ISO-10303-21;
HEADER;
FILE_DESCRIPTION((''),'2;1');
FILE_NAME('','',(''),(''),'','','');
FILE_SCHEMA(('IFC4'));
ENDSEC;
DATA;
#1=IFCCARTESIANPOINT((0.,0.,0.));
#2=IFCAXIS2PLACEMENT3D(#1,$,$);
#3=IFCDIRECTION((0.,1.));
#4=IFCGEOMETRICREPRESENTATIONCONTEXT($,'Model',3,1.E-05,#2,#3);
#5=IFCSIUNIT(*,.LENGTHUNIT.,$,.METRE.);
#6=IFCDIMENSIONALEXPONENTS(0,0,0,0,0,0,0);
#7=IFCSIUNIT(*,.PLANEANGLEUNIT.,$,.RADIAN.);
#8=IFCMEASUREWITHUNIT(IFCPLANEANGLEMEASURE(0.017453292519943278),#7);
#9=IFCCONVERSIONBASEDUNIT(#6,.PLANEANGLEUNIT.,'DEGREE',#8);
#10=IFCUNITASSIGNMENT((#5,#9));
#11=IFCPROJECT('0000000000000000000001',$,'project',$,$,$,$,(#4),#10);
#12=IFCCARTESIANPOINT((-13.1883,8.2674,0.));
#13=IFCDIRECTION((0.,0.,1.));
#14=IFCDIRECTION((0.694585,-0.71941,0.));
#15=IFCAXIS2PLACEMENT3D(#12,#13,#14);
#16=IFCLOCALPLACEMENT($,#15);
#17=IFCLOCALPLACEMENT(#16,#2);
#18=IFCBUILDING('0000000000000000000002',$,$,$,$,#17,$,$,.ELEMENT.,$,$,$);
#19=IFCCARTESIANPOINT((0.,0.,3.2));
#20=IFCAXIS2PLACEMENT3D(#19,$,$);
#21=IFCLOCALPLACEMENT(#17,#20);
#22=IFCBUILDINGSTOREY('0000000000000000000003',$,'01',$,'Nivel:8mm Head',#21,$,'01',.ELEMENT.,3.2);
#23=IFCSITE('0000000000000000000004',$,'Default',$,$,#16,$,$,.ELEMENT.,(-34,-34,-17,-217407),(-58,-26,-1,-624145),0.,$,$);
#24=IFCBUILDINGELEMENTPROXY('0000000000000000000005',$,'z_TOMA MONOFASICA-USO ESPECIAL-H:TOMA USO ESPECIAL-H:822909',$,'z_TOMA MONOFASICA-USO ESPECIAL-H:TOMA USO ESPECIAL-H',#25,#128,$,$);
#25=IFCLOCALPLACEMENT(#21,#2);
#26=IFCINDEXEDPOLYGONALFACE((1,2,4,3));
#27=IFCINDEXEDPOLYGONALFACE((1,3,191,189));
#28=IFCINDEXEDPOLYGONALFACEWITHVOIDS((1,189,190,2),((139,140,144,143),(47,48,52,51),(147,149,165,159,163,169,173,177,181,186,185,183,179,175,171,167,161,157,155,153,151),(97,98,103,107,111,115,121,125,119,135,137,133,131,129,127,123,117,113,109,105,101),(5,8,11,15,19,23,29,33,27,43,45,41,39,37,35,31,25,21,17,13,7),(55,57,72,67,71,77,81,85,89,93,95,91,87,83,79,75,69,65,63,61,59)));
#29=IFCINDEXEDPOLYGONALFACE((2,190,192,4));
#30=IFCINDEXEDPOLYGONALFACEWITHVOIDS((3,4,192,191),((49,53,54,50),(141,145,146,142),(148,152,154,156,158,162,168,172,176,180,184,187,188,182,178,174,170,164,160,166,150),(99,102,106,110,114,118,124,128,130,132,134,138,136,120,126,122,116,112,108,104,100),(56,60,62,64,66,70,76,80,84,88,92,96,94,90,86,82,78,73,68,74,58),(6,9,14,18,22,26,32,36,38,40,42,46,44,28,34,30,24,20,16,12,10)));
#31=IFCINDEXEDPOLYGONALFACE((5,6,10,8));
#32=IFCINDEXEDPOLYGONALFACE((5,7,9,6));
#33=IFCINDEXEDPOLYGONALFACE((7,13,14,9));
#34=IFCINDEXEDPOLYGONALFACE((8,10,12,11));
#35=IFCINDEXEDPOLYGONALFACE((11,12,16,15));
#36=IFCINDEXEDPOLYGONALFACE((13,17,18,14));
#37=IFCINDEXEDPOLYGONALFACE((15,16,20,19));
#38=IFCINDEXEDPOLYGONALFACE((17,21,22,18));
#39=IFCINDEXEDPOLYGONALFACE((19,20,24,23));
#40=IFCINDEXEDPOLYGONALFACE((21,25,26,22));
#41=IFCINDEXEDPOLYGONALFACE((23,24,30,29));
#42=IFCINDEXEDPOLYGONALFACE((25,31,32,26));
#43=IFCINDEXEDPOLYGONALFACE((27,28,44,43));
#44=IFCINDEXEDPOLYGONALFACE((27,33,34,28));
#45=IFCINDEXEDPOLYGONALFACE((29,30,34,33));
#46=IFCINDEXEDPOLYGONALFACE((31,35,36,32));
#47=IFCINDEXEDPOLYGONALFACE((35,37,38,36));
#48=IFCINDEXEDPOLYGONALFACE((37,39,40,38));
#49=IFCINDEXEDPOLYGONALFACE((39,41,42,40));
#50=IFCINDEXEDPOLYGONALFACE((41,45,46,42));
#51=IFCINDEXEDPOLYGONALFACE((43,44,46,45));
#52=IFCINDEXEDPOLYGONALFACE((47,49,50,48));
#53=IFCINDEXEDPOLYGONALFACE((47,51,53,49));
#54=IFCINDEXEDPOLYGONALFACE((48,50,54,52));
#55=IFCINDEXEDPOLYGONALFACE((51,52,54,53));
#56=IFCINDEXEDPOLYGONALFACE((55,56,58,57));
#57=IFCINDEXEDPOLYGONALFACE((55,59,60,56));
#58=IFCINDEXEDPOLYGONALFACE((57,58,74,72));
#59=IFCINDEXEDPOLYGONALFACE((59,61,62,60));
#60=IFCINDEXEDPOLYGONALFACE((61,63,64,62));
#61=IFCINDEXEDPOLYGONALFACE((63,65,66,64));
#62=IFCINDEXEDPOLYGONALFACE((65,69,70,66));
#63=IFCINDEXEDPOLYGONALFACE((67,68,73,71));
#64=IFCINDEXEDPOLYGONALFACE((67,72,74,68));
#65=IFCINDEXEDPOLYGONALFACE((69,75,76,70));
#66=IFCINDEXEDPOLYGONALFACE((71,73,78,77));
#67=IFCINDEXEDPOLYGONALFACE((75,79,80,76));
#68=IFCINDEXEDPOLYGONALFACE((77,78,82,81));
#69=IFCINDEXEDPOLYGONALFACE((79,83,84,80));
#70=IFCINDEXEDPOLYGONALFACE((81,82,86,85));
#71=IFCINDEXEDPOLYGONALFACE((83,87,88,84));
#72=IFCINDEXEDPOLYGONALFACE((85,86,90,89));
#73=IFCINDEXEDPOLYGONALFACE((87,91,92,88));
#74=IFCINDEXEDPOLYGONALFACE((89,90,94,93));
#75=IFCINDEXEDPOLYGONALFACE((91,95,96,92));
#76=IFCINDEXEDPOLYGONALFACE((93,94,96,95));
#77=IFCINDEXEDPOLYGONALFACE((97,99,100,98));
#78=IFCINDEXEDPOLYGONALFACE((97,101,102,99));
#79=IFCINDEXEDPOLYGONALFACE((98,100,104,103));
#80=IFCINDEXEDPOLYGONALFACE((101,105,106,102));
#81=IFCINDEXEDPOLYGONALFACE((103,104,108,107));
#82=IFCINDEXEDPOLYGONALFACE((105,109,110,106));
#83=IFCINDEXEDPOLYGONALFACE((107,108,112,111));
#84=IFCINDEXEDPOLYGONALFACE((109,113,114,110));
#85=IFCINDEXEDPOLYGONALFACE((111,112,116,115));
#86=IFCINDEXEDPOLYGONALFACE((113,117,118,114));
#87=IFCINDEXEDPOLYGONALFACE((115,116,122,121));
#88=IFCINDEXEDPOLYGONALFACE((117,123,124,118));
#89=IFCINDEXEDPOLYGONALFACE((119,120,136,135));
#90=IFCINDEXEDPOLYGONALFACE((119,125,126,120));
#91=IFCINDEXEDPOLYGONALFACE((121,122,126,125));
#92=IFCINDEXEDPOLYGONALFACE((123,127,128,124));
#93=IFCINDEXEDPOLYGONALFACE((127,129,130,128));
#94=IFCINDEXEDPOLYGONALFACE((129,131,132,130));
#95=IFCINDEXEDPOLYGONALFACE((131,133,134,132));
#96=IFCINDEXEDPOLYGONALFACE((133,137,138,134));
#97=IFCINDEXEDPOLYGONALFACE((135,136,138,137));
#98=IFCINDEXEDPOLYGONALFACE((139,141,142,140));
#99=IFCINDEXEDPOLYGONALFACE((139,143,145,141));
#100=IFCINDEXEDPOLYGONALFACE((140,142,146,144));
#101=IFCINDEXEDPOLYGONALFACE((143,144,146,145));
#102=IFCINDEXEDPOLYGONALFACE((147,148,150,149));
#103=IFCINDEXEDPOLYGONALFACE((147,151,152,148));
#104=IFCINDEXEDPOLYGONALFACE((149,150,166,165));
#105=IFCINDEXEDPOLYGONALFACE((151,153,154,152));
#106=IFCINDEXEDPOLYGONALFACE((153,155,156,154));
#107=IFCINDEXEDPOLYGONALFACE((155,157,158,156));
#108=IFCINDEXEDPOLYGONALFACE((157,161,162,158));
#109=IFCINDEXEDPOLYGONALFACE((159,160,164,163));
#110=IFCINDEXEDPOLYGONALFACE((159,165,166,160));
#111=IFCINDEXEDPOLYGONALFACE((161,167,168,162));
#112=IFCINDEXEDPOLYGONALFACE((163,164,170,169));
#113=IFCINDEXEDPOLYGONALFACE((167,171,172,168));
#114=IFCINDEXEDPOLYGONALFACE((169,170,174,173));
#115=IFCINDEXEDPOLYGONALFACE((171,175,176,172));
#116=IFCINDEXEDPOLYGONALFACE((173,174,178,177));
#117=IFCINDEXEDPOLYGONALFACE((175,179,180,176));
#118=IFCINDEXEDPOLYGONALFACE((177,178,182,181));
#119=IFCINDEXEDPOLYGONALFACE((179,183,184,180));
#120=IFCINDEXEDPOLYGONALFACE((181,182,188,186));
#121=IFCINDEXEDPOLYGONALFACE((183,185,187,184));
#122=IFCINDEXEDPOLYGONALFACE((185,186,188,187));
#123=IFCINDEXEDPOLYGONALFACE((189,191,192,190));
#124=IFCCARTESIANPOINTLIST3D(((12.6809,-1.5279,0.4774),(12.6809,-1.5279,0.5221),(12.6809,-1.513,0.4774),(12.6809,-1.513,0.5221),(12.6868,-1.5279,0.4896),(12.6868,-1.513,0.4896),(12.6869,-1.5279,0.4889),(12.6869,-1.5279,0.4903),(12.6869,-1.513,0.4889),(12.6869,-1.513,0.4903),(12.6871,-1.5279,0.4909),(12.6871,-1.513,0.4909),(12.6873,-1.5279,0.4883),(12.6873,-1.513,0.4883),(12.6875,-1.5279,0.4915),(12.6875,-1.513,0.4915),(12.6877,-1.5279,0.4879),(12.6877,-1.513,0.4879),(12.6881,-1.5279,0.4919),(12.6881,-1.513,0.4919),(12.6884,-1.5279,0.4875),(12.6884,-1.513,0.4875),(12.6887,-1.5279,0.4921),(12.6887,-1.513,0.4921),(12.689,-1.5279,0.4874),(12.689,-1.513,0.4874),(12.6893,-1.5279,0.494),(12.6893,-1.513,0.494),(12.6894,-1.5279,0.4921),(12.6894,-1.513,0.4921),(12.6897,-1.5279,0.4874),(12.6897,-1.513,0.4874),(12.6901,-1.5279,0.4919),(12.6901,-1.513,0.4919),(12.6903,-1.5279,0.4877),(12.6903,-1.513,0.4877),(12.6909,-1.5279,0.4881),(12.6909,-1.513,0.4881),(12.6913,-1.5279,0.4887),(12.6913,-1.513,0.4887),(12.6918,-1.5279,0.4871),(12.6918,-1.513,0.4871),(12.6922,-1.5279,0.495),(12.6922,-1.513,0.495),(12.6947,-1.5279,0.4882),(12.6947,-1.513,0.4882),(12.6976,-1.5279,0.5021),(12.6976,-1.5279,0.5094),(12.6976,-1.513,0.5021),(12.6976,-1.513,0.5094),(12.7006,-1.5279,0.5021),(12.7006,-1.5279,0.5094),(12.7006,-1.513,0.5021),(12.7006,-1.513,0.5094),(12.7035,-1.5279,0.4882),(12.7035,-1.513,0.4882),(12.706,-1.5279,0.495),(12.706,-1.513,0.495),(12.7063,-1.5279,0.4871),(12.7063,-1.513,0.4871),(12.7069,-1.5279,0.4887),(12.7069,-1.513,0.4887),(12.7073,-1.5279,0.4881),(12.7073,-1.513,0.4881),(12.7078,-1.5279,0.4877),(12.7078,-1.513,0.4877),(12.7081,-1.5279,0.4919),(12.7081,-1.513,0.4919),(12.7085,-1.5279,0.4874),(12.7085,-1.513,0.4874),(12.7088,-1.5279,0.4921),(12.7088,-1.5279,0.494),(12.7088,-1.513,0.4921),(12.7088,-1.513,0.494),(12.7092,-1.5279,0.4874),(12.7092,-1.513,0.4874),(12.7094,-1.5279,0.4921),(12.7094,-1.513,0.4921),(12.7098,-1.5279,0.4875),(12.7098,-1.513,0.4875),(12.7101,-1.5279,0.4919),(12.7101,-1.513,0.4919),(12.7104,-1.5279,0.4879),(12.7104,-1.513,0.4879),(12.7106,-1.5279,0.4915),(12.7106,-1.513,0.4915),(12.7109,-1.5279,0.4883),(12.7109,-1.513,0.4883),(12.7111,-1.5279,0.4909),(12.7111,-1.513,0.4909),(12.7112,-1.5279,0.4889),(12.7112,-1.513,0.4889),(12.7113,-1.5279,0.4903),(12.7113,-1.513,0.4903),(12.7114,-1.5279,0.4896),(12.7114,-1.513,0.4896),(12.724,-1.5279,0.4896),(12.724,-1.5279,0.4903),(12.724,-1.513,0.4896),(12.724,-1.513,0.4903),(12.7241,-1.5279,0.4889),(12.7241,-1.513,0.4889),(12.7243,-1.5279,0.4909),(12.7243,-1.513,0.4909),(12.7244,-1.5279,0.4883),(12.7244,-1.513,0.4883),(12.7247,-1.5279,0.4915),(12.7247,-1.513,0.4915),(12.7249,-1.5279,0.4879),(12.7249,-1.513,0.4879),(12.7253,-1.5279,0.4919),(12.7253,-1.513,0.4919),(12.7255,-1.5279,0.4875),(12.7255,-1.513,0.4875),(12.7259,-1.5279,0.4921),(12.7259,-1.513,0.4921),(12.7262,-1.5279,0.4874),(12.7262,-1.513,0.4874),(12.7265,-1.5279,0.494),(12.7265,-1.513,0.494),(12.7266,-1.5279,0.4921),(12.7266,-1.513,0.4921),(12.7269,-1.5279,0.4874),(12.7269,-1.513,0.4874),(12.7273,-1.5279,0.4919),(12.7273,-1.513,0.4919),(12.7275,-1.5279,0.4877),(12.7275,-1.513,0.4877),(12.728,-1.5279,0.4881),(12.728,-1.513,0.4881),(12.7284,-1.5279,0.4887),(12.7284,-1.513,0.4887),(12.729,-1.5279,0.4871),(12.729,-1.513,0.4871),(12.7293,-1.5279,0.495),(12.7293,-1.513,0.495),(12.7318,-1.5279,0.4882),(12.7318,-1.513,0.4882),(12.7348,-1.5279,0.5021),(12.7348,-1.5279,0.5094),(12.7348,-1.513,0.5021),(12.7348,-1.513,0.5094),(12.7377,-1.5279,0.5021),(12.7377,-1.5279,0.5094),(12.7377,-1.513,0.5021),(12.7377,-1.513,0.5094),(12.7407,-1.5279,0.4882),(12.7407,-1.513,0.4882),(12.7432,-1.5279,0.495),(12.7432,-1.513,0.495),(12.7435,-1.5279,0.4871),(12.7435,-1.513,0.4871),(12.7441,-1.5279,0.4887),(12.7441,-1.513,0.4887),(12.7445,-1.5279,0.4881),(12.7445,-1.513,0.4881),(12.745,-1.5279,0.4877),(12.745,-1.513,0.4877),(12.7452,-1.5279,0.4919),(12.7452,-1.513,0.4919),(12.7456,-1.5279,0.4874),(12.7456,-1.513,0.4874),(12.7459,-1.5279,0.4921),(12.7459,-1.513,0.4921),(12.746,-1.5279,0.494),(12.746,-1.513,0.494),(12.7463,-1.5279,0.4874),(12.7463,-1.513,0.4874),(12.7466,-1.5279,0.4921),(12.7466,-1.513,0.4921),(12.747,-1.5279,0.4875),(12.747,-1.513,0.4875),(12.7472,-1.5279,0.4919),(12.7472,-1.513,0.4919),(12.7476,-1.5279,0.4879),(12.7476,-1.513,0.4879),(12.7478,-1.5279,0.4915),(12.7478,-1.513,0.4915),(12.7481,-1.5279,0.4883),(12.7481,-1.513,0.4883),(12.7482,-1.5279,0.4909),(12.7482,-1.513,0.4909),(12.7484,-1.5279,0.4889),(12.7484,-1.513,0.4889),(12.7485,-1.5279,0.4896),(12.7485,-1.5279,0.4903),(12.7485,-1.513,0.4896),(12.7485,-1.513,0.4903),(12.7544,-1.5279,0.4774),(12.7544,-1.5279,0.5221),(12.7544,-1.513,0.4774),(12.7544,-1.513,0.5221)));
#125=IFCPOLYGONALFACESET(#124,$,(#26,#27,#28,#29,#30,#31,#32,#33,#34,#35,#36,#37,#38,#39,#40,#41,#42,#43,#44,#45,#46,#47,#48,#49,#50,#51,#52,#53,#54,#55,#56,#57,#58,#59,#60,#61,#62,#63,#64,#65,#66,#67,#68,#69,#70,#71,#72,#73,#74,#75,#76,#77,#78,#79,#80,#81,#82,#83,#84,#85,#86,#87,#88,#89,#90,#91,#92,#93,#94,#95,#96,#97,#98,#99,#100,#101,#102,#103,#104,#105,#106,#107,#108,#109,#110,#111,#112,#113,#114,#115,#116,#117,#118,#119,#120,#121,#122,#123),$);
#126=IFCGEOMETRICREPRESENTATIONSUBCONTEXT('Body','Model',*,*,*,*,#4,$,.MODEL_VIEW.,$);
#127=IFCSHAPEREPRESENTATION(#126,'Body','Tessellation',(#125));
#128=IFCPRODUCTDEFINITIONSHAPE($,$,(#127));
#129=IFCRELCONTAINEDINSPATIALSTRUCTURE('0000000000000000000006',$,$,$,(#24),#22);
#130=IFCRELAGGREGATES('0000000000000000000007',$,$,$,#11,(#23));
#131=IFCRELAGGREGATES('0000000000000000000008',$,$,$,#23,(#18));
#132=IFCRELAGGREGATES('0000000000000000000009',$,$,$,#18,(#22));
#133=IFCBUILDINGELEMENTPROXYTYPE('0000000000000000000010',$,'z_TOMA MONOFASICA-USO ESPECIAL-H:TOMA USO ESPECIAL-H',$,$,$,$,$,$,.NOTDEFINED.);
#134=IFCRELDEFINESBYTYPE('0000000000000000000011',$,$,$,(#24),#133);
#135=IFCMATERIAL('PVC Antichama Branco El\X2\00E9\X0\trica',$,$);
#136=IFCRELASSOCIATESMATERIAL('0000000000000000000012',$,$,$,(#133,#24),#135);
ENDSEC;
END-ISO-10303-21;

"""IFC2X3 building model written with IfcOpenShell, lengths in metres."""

from ifc_helpers import new_model, entity, si_unit, converted_unit, direction, frame, frame_2d, origin, place, context, subcontext, project, spatial, polyline, circle_curve, parameter, trimmed, segment, composite_curve, outline, extrude, source, transform, mapped, material, type_object, type_shapes, element, save


model = new_model("IFC2X3")

# Units and contexts
model_context = context("Model", 3, precision=1e-05, world=origin(), true_north=direction((0.0, 1.0)))
body_context = subcontext(model_context, "Body", "Model", "MODEL_VIEW")
ifc_project = project(units=[si_unit("LENGTHUNIT", "METRE"), converted_unit("PLANEANGLEUNIT", "DEGREE", entity("IfcPlaneAngleMeasure", 0.017453292519943278), si_unit("PLANEANGLEUNIT", "RADIAN"), dimensions=[0, 0, 0, 0, 0, 0, 0])], contexts=[model_context])

# Site, building, storey
site_placement = place(None, frame((-13.1883, 8.2674, 0.0), z_axis=(0.0, 0.0, 1.0), x_axis=(0.694585, -0.71941, 0.0)))
site = spatial("IfcSite", under=ifc_project, at=site_placement, Name="Default", CompositionType="ELEMENT", RefLatitude=(-34, -34, -17, -217407), RefLongitude=(-58, -26, -1, -624145), RefElevation=0.0)
building_placement = place(site_placement, origin())
building = spatial("IfcBuilding", under=site, at=building_placement, CompositionType="ELEMENT")
storey_placement = place(building_placement, frame((0.0, 0.0, 3.2)))
storey = spatial("IfcBuildingStorey", under=building, at=storey_placement, Name="01", ObjectType="Nivel:8mm Head", LongName="01", CompositionType="ELEMENT", Elevation=3.2)

# Building element proxy
ifc_material_1 = material(Name="PVC Antichama Branco Elétrica")
building_element_proxy_type_1 = type_object("IfcBuildingElementProxyType", Name="z_TOMA MONOFASICA-USO ESPECIAL-H:TOMA USO ESPECIAL-H", PredefinedType="NOTDEFINED", material=ifc_material_1)
shared_shape_1 = source(origin(), body_context, "Body", "SweptSolid", [
    extrude(outline(polyline([(-0.0368, -0.0223), (0.0368, -0.0223), (0.0368, 0.0223), (-0.0368, 0.0223), (-0.0368, -0.0223)]), holes=[composite_curve([segment(polyline([(0.0141, 0.0115), (0.0116, 0.0047)]), True, "CONTINUOUS"), segment(polyline([(0.0116, 0.0047), (0.0088, 0.0057)]), True, "CONTINUOUS"), segment(polyline([(0.0088, 0.0057), (0.0096, 0.0078)]), True, "CONTINUOUS"), segment(trimmed(circle_curve(frame_2d((0.0087, 0.0099), x_axis=(1.0, 0.0)), 0.0024), [parameter(27.118901)], [parameter(292.881099)], True, "PARAMETER"), False, "CONTINUOUS"), segment(polyline([(0.0108, 0.011), (0.0113, 0.0126)]), True, "CONTINUOUS"), segment(polyline([(0.0113, 0.0126), (0.0141, 0.0115)]), True, "CONTINUOUS")], self_intersect=False), composite_curve([segment(polyline([(0.0255, 0.0047), (0.023, 0.0115)]), True, "CONTINUOUS"), segment(polyline([(0.023, 0.0115), (0.0258, 0.0126)]), True, "CONTINUOUS"), segment(polyline([(0.0258, 0.0126), (0.0264, 0.011)]), True, "CONTINUOUS"), segment(trimmed(circle_curve(frame_2d((0.0285, 0.0099), x_axis=(1.0, 0.0)), 0.0024), [parameter(247.118901)], [parameter(152.881099)], True, "PARAMETER"), False, "CONTINUOUS"), segment(polyline([(0.0276, 0.0078), (0.0283, 0.0057)]), True, "CONTINUOUS"), segment(polyline([(0.0283, 0.0057), (0.0255, 0.0047)]), True, "CONTINUOUS")], self_intersect=False), polyline([(0.0201, -0.0024), (0.0201, -0.0097), (0.0171, -0.0097), (0.0171, -0.0024), (0.0201, -0.0024)]), composite_curve([segment(polyline([(-0.0141, 0.0115), (-0.0113, 0.0126)]), True, "CONTINUOUS"), segment(polyline([(-0.0113, 0.0126), (-0.0108, 0.011)]), True, "CONTINUOUS"), segment(trimmed(circle_curve(frame_2d((-0.0087, 0.0099), x_axis=(1.0, 0.0)), 0.0024), [parameter(247.118901)], [parameter(152.881099)], True, "PARAMETER"), False, "CONTINUOUS"), segment(polyline([(-0.0096, 0.0078), (-0.0088, 0.0057)]), True, "CONTINUOUS"), segment(polyline([(-0.0088, 0.0057), (-0.0116, 0.0047)]), True, "CONTINUOUS"), segment(polyline([(-0.0116, 0.0047), (-0.0141, 0.0115)]), True, "CONTINUOUS")], self_intersect=False), composite_curve([segment(polyline([(-0.0255, 0.0047), (-0.0283, 0.0057)]), True, "CONTINUOUS"), segment(polyline([(-0.0283, 0.0057), (-0.0276, 0.0078)]), True, "CONTINUOUS"), segment(trimmed(circle_curve(frame_2d((-0.0285, 0.0099), x_axis=(1.0, 0.0)), 0.0024), [parameter(27.118901)], [parameter(292.881099)], True, "PARAMETER"), False, "CONTINUOUS"), segment(polyline([(-0.0264, 0.011), (-0.0258, 0.0126)]), True, "CONTINUOUS"), segment(polyline([(-0.0258, 0.0126), (-0.023, 0.0115)]), True, "CONTINUOUS"), segment(polyline([(-0.023, 0.0115), (-0.0255, 0.0047)]), True, "CONTINUOUS")], self_intersect=False), polyline([(-0.0201, -0.0024), (-0.0171, -0.0024), (-0.0171, -0.0097), (-0.0201, -0.0097), (-0.0201, -0.0024)])]), frame((0.0, -0.005, 0.0223), z_axis=(0.0, 1.0, 0.0), x_axis=(1.0, 0.0, 0.0)), (0.0, 0.0, 1.0), 0.0148),
])
type_shapes(building_element_proxy_type_1, [shared_shape_1])
for number, where, name in (
    (1, (12.7177, -1.5229, 0.4774), "z_TOMA MONOFASICA-USO ESPECIAL-H:TOMA USO ESPECIAL-H:822909"),
):
    element("IfcBuildingElementProxy", number, at=place(storey_placement, frame(where)), inside=storey, type_object=building_element_proxy_type_1, material=ifc_material_1, Name=name, ObjectType="z_TOMA MONOFASICA-USO ESPECIAL-H:TOMA USO ESPECIAL-H", context=body_context, shape_type="MappedRepresentation", body=[
        mapped(shared_shape_1, transform((0.0, 0.0, 0.0), scale=1.0)),
    ])

save(model, "model.ifc")
